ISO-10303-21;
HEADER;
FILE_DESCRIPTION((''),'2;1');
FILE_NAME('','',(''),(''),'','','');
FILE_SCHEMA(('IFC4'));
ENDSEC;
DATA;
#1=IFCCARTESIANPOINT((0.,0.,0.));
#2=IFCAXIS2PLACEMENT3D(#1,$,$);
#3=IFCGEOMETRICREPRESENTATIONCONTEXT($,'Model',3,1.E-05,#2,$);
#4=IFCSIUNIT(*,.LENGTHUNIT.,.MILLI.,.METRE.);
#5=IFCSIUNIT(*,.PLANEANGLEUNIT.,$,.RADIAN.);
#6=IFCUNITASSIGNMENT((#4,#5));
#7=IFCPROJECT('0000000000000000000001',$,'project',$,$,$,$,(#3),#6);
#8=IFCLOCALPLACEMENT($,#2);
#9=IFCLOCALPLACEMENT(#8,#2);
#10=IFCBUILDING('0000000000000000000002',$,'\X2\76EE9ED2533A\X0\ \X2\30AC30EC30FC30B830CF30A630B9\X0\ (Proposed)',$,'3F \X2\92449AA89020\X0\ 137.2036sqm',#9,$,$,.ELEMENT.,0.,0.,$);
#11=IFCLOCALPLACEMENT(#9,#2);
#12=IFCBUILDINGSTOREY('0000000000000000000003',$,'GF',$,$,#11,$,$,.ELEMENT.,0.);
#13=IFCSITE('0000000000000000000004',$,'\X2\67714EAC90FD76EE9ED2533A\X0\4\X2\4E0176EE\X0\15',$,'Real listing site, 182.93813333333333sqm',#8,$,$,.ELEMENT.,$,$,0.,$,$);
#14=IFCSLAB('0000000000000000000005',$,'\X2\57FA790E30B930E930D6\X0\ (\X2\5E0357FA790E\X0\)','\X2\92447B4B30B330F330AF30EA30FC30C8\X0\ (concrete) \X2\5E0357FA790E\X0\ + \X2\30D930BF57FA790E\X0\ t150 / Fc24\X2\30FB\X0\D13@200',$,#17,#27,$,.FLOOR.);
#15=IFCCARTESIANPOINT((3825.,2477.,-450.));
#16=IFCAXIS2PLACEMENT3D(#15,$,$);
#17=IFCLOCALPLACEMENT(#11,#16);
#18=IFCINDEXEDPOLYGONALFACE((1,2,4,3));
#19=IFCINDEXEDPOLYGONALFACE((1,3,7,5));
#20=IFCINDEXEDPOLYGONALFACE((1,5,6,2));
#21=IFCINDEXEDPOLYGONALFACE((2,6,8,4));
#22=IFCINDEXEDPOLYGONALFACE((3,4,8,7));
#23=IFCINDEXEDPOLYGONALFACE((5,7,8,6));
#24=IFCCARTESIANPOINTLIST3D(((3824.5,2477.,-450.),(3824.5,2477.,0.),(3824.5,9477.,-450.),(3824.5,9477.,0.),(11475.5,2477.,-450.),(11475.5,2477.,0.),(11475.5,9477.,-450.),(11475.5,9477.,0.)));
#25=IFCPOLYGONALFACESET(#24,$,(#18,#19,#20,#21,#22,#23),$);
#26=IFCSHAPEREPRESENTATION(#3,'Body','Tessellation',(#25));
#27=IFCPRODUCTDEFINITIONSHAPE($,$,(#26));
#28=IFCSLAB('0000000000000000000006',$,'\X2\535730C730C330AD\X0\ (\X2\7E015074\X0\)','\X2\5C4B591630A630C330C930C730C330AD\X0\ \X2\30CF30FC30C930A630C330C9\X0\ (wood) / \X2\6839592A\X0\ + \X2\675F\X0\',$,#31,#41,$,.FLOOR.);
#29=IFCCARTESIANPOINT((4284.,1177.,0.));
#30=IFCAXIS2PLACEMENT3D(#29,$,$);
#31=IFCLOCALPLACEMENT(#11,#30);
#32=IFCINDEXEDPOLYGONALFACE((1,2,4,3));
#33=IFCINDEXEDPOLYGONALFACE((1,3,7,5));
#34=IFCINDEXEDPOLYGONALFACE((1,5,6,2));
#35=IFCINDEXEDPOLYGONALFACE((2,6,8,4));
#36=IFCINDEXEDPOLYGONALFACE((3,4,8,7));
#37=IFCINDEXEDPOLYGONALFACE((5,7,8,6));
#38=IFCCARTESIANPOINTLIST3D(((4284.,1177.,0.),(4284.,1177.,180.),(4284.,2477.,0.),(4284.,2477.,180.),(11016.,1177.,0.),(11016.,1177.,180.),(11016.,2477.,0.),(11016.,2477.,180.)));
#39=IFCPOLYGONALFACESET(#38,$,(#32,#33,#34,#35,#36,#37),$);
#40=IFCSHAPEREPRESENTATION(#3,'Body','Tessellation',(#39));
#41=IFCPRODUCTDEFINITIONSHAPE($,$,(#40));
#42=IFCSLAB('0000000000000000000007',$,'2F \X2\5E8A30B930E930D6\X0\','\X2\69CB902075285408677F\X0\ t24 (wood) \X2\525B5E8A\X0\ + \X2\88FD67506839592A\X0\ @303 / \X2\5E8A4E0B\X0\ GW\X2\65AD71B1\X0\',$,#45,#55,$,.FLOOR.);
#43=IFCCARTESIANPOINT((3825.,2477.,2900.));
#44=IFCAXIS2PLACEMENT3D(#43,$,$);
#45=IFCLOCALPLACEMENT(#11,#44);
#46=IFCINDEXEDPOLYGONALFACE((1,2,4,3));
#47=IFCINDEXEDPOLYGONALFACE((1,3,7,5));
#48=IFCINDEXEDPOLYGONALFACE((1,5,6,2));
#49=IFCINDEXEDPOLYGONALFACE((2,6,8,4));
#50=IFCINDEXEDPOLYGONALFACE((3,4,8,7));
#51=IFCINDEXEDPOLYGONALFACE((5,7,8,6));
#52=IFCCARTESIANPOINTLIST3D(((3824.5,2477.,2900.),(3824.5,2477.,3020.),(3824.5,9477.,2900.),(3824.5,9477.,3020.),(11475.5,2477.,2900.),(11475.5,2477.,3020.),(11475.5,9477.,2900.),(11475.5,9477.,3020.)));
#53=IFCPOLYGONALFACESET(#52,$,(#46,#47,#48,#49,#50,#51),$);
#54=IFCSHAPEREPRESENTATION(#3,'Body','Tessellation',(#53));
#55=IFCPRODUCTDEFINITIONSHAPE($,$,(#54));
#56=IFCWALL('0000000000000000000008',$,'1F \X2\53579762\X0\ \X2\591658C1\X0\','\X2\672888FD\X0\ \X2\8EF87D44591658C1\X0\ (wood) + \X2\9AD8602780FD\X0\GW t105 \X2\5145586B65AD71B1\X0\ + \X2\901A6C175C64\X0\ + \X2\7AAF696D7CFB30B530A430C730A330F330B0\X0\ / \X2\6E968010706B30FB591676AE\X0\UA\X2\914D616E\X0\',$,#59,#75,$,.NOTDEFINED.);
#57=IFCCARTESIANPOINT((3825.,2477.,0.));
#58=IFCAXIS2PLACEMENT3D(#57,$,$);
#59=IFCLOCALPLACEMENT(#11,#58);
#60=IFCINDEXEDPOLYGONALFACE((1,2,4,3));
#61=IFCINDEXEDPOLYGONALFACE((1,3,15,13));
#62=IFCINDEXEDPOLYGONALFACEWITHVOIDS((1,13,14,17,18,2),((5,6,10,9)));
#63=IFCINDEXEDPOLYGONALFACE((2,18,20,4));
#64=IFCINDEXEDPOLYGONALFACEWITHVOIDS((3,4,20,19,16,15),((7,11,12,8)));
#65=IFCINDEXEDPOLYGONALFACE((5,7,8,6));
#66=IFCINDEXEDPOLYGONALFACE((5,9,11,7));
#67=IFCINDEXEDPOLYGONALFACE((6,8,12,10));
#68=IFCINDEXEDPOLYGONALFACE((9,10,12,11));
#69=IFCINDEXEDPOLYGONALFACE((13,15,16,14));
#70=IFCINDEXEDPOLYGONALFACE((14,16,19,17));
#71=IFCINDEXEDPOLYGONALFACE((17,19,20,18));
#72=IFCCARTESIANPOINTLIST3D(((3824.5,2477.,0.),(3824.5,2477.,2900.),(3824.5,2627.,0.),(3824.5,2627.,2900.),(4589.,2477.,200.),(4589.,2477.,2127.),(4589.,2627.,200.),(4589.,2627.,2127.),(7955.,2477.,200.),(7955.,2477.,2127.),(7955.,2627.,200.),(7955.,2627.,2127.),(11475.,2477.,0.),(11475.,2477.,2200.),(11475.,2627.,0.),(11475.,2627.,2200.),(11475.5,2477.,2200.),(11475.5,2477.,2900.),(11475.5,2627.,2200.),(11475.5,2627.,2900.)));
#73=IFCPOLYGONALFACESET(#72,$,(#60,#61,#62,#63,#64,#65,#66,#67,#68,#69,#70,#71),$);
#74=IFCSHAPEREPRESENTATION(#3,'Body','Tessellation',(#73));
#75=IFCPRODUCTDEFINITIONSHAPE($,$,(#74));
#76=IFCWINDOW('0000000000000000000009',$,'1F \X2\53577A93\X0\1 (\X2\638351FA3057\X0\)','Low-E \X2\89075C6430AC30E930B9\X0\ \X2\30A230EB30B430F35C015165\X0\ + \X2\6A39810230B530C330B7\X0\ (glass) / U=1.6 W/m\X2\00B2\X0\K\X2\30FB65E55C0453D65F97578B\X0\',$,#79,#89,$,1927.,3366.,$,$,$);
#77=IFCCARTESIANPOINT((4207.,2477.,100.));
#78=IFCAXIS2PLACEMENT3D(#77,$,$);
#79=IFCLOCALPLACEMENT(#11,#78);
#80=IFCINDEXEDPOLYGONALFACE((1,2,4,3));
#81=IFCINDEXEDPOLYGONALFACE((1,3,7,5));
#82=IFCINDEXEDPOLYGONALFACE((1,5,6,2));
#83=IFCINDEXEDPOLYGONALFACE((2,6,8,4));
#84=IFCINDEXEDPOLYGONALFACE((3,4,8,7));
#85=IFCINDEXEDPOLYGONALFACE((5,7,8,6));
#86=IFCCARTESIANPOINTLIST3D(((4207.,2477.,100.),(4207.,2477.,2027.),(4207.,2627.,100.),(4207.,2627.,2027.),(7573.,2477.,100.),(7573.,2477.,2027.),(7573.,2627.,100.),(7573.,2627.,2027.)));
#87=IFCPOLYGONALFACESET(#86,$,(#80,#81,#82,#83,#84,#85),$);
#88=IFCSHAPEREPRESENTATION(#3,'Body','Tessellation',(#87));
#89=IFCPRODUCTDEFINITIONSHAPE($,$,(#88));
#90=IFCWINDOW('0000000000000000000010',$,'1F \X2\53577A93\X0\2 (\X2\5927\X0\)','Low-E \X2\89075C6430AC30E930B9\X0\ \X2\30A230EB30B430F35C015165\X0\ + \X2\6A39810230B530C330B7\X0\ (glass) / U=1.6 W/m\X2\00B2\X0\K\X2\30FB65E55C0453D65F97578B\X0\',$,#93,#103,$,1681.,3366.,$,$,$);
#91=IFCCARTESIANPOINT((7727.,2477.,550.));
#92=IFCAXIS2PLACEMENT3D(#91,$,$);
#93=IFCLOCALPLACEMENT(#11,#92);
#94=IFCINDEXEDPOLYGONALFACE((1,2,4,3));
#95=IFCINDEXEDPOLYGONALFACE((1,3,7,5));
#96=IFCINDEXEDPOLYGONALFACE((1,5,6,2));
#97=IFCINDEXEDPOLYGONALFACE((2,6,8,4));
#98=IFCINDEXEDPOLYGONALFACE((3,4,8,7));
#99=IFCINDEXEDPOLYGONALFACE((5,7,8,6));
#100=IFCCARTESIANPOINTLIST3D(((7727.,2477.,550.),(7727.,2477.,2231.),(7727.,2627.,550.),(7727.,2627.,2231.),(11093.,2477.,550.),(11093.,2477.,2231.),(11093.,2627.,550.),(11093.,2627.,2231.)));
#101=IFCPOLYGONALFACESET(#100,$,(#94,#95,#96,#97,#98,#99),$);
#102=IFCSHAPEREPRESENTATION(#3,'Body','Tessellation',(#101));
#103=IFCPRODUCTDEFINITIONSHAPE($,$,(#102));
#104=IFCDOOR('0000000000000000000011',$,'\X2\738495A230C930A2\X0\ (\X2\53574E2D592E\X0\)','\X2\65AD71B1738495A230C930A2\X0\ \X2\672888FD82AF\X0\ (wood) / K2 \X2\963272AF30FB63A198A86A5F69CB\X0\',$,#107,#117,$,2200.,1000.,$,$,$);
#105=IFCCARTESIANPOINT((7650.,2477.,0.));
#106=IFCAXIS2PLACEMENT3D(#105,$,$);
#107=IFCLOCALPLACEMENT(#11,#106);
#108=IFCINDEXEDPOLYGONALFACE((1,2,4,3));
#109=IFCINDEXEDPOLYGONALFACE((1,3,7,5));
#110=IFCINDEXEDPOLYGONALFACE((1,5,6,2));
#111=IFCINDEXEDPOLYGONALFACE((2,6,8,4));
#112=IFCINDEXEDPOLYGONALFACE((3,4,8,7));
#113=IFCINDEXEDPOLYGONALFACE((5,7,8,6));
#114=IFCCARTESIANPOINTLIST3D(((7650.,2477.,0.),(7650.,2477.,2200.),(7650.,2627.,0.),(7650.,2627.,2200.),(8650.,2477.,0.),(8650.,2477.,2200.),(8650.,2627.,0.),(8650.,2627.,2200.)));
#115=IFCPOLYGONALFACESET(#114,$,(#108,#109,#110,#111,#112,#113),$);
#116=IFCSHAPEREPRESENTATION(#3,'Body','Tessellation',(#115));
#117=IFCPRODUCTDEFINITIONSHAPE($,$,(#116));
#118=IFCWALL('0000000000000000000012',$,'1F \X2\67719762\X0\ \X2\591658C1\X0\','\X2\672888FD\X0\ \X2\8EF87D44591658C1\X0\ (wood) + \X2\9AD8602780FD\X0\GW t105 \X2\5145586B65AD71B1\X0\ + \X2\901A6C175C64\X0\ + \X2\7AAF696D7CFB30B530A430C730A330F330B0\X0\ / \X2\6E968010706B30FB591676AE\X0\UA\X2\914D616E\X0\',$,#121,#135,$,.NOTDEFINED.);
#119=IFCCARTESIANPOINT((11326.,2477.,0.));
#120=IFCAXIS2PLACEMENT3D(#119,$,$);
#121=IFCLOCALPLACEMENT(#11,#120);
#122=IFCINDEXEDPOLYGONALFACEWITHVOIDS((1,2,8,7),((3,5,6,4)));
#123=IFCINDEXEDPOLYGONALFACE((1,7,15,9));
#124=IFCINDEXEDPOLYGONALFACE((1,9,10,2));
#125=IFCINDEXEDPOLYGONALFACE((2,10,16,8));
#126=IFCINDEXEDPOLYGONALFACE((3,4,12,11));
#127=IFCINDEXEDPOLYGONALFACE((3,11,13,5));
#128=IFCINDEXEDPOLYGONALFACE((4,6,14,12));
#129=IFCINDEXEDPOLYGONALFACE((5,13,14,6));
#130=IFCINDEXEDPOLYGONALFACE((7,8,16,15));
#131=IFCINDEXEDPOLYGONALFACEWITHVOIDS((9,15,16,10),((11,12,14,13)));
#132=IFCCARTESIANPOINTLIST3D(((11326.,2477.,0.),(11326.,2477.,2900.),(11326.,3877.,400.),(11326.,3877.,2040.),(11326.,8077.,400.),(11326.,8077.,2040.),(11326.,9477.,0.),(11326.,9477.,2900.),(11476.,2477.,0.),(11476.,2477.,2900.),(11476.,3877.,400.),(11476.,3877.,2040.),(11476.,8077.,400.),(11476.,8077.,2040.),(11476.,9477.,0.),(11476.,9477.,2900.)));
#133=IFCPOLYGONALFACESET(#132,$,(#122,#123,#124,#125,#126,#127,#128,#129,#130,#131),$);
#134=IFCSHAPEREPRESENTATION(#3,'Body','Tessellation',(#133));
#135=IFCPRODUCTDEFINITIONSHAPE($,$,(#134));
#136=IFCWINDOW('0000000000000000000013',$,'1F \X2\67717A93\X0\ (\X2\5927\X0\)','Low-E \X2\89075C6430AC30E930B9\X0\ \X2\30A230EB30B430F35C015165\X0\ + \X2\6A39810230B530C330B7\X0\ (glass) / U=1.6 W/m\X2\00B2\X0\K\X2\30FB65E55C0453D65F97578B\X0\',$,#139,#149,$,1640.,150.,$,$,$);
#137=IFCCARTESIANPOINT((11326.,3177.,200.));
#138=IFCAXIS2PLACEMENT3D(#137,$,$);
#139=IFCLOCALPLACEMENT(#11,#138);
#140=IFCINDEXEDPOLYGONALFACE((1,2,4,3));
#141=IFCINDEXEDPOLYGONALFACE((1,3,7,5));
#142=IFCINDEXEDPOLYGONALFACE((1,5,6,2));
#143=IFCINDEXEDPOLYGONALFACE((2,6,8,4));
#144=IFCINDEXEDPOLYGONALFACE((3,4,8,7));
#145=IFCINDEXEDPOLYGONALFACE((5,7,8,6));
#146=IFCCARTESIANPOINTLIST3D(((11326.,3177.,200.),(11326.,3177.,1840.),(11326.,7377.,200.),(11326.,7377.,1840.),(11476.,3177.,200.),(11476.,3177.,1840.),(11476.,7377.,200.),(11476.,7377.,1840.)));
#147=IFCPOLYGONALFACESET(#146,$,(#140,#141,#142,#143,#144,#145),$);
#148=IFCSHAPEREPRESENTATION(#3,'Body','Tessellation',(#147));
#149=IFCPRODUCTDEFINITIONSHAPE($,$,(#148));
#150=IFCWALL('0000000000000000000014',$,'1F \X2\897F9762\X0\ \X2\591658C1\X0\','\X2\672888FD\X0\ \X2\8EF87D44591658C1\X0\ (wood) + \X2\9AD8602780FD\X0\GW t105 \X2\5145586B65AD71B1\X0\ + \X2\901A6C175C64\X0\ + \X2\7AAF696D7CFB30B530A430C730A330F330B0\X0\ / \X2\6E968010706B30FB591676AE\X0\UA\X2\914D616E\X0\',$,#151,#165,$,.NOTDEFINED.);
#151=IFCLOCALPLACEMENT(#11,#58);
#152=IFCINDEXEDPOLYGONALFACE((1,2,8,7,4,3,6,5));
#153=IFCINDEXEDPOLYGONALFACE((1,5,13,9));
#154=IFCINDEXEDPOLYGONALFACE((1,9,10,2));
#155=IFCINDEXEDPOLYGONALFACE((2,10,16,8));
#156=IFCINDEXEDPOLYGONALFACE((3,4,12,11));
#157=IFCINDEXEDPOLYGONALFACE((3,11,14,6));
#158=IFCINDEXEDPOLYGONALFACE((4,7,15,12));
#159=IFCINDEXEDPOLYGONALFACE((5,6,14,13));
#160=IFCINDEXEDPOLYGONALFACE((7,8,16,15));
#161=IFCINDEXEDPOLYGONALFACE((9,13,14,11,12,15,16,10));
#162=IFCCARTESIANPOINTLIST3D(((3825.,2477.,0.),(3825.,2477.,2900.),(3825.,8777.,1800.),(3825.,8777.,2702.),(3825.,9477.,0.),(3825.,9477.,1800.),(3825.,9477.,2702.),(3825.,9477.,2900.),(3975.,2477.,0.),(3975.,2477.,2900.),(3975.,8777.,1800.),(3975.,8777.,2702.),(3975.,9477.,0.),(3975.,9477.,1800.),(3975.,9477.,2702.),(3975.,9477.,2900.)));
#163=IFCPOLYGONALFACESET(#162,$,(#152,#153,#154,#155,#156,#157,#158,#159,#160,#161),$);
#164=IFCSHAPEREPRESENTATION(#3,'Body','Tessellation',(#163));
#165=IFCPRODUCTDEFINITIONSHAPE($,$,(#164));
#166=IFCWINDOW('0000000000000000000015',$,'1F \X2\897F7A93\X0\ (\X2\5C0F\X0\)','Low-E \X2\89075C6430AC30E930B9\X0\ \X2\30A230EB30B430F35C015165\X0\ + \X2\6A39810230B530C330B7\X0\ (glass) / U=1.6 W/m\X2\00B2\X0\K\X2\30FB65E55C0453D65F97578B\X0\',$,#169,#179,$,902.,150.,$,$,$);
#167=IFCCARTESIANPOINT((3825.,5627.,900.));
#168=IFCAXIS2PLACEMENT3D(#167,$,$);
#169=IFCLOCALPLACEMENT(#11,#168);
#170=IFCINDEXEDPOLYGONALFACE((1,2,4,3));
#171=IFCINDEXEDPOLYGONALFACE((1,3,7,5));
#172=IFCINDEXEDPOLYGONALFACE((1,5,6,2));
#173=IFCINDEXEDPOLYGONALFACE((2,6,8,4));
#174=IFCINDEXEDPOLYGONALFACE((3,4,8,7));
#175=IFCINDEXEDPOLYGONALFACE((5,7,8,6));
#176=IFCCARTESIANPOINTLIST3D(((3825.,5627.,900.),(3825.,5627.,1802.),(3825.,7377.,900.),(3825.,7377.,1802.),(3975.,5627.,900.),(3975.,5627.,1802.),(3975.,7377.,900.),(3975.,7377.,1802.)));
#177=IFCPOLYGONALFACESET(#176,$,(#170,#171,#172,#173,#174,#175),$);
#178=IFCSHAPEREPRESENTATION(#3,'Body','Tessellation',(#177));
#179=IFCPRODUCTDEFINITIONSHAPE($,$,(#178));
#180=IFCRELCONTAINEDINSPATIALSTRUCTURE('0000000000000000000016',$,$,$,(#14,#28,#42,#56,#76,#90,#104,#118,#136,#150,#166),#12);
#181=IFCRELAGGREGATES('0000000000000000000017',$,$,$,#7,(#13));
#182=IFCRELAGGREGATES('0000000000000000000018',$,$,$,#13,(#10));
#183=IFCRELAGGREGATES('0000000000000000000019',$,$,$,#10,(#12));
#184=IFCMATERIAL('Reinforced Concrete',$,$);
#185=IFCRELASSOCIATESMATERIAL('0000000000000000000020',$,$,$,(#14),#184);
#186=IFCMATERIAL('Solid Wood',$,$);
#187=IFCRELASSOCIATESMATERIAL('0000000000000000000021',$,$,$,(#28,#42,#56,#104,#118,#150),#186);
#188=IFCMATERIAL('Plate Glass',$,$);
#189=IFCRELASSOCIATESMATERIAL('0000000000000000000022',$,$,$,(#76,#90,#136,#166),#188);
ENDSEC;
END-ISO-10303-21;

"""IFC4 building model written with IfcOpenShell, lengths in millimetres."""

from ifc_helpers import new_model, si_unit, frame, frame_2d, origin, place, context, project, spatial, rectangle, extrude, material, element, fill, save


model = new_model("IFC4")

# Units and contexts
model_context = context("Model", 3, precision=1e-05, world=origin())
ifc_project = project(units=[si_unit("LENGTHUNIT", "METRE", prefix="MILLI"), si_unit("PLANEANGLEUNIT", "RADIAN")], contexts=[model_context])

# Site, building, storey
site_placement = place(None, origin())
site = spatial("IfcSite", under=ifc_project, at=site_placement, Name="東京都目黒区4丁目15", ObjectType="Real listing site, 182.93813333333333sqm", CompositionType="ELEMENT", RefElevation=0.0)
building_placement = place(site_placement, origin())
building = spatial("IfcBuilding", under=site, at=building_placement, Name="目黒区 ガレージハウス (Proposed)", ObjectType="3F 鉄骨造 137.2036sqm", CompositionType="ELEMENT", ElevationOfRefHeight=0.0, ElevationOfTerrain=0.0)
storey_placement = place(building_placement, origin())
storey = spatial("IfcBuildingStorey", under=building, at=storey_placement, Name="GF", CompositionType="ELEMENT", Elevation=0.0)

# Slabs
ifc_material_1 = material(Name="Reinforced Concrete")
slab_1_placement = place(storey_placement, frame((3825.0, 2477.0, -450.0)))
element("IfcSlab", 1, at=slab_1_placement, inside=storey, material=ifc_material_1, Name="基礎スラブ (布基礎)", Description="鉄筋コンクリート (concrete) 布基礎 + ベタ基礎 t150 / Fc24・D13@200", PredefinedType="FLOOR", context=model_context, shape_type="SweptSolid", body=[
    extrude(rectangle(XDim=7651.0, YDim=7000.0, at=frame_2d((3825.0, 3500.0))), frame((3825.0, 2477.0, -450.0)), (0.0, 0.0, 1.0), 450.0),
])
ifc_material_2 = material(Name="Solid Wood")
slab_2_placement = place(storey_placement, frame((4284.0, 1177.0, 0.0)))
element("IfcSlab", 2, at=slab_2_placement, inside=storey, material=ifc_material_2, Name="南デッキ (縁側)", Description="屋外ウッドデッキ ハードウッド (wood) / 根太 + 束", PredefinedType="FLOOR", context=model_context, shape_type="SweptSolid", body=[
    extrude(rectangle(XDim=6732.0, YDim=1300.0, at=frame_2d((3366.0, 650.0))), frame((4284.0, 1177.0, 0.0)), (0.0, 0.0, 1.0), 180.0),
])
slab_3_placement = place(storey_placement, frame((3825.0, 2477.0, 2900.0)))
element("IfcSlab", 3, at=slab_3_placement, inside=storey, material=ifc_material_2, Name="2F 床スラブ", Description="構造用合板 t24 (wood) 剛床 + 製材根太 @303 / 床下 GW断熱", PredefinedType="FLOOR", context=model_context, shape_type="SweptSolid", body=[
    extrude(rectangle(XDim=7651.0, YDim=7000.0, at=frame_2d((3825.0, 3500.0))), frame((3825.0, 2477.0, 2900.0)), (0.0, 0.0, 1.0), 120.0),
])

# Wall, openings, windows, door
wall_1_placement = place(storey_placement, frame((3825.0, 2477.0, 0.0)))
wall_1 = element("IfcWall", 4, at=wall_1_placement, inside=storey, material=ifc_material_2, Name="1F 南面 外壁", Description="木製 軸組外壁 (wood) + 高性能GW t105 充填断熱 + 通気層 + 窯業系サイディング / 準耐火・外皮UA配慮", PredefinedType="NOTDEFINED", context=model_context, shape_type="SweptSolid", body=[
    extrude(rectangle(XDim=7651.0, YDim=150.0, at=frame_2d((3825.0, 75.0))), frame((3825.0, 2477.0, 0.0)), (0.0, 0.0, 1.0), 2900.0),
])
opening_1_placement = place(storey_placement, frame((4207.0, 2477.0, 100.0)))
opening_1 = element("IfcOpeningElement", 5, at=opening_1_placement, cuts=wall_1, PredefinedType="NOTDEFINED", context=model_context, shape_type="SweptSolid", body=[
    extrude(rectangle(XDim=3366.0, YDim=150.0, at=frame_2d((1683.0, 75.0))), frame((4207.0, 2477.0, 100.0)), (0.0, 0.0, 1.0), 1927.0),
])
opening_2_placement = place(storey_placement, frame((7727.0, 2477.0, 550.0)))
opening_2 = element("IfcOpeningElement", 6, at=opening_2_placement, cuts=wall_1, PredefinedType="NOTDEFINED", context=model_context, shape_type="SweptSolid", body=[
    extrude(rectangle(XDim=3366.0, YDim=150.0, at=frame_2d((1683.0, 75.0))), frame((7727.0, 2477.0, 550.0)), (0.0, 0.0, 1.0), 1681.0),
])
opening_3_placement = place(storey_placement, frame((7650.0, 2477.0, 0.0)))
opening_3 = element("IfcOpeningElement", 7, at=opening_3_placement, cuts=wall_1, PredefinedType="NOTDEFINED", context=model_context, shape_type="SweptSolid", body=[
    extrude(rectangle(XDim=1000.0, YDim=150.0, at=frame_2d((500.0, 75.0))), frame((7650.0, 2477.0, 0.0)), (0.0, 0.0, 1.0), 2200.0),
])
ifc_material_3 = material(Name="Plate Glass")
window_1_placement = place(storey_placement, frame((4207.0, 2477.0, 100.0)))
window_1 = element("IfcWindow", 8, at=window_1_placement, inside=storey, material=ifc_material_3, Name="1F 南窓1 (掃出し)", Description="Low-E 複層ガラス アルゴン封入 + 樹脂サッシ (glass) / U=1.6 W/m²K・日射取得型", OverallHeight=1927.0, OverallWidth=3366.0, context=model_context, shape_type="SweptSolid", body=[
    extrude(rectangle(XDim=3366.0, YDim=150.0, at=frame_2d((1683.0, 75.0))), frame((4207.0, 2477.0, 100.0)), (0.0, 0.0, 1.0), 1927.0),
])
fill(opening_1, window_1)
window_2_placement = place(storey_placement, frame((7727.0, 2477.0, 550.0)))
window_2 = element("IfcWindow", 9, at=window_2_placement, inside=storey, material=ifc_material_3, Name="1F 南窓2 (大)", Description="Low-E 複層ガラス アルゴン封入 + 樹脂サッシ (glass) / U=1.6 W/m²K・日射取得型", OverallHeight=1681.0, OverallWidth=3366.0, context=model_context, shape_type="SweptSolid", body=[
    extrude(rectangle(XDim=3366.0, YDim=150.0, at=frame_2d((1683.0, 75.0))), frame((7727.0, 2477.0, 550.0)), (0.0, 0.0, 1.0), 1681.0),
])
fill(opening_2, window_2)
door_placement = place(storey_placement, frame((7650.0, 2477.0, 0.0)))
door = element("IfcDoor", 10, at=door_placement, inside=storey, material=ifc_material_2, Name="玄関ドア (南中央)", Description="断熱玄関ドア 木製芯 (wood) / K2 防犯・採風機構", OverallHeight=2200.0, OverallWidth=1000.0, context=model_context, shape_type="SweptSolid", body=[
    extrude(rectangle(XDim=1000.0, YDim=150.0, at=frame_2d((500.0, 75.0))), frame((7650.0, 2477.0, 0.0)), (0.0, 0.0, 1.0), 2200.0),
])
fill(opening_3, door)

# Walls, openings, windows
wall_2_placement = place(storey_placement, frame((11326.0, 2477.0, 0.0)))
wall_2 = element("IfcWall", 11, at=wall_2_placement, inside=storey, material=ifc_material_2, Name="1F 東面 外壁", Description="木製 軸組外壁 (wood) + 高性能GW t105 充填断熱 + 通気層 + 窯業系サイディング / 準耐火・外皮UA配慮", PredefinedType="NOTDEFINED", context=model_context, shape_type="SweptSolid", body=[
    extrude(rectangle(XDim=150.0, YDim=7000.0, at=frame_2d((75.0, 3500.0))), frame((11326.0, 2477.0, 0.0)), (0.0, 0.0, 1.0), 2900.0),
])
opening_4_placement = place(storey_placement, frame((11326.0, 3177.0, 200.0)))
opening_4 = element("IfcOpeningElement", 12, at=opening_4_placement, cuts=wall_2, PredefinedType="NOTDEFINED", context=model_context, shape_type="SweptSolid", body=[
    extrude(rectangle(XDim=150.0, YDim=4200.0, at=frame_2d((75.0, 2100.0))), frame((11326.0, 3177.0, 200.0)), (0.0, 0.0, 1.0), 1640.0),
])
window_3_placement = place(storey_placement, frame((11326.0, 3177.0, 200.0)))
window_3 = element("IfcWindow", 13, at=window_3_placement, inside=storey, material=ifc_material_3, Name="1F 東窓 (大)", Description="Low-E 複層ガラス アルゴン封入 + 樹脂サッシ (glass) / U=1.6 W/m²K・日射取得型", OverallHeight=1640.0, OverallWidth=150.0, context=model_context, shape_type="SweptSolid", body=[
    extrude(rectangle(XDim=150.0, YDim=4200.0, at=frame_2d((75.0, 2100.0))), frame((11326.0, 3177.0, 200.0)), (0.0, 0.0, 1.0), 1640.0),
])
fill(opening_4, window_3)
wall_3_placement = place(storey_placement, frame((3825.0, 2477.0, 0.0)))
wall_3 = element("IfcWall", 14, at=wall_3_placement, inside=storey, material=ifc_material_2, Name="1F 西面 外壁", Description="木製 軸組外壁 (wood) + 高性能GW t105 充填断熱 + 通気層 + 窯業系サイディング / 準耐火・外皮UA配慮", PredefinedType="NOTDEFINED", context=model_context, shape_type="SweptSolid", body=[
    extrude(rectangle(XDim=150.0, YDim=7000.0, at=frame_2d((75.0, 3500.0))), frame((3825.0, 2477.0, 0.0)), (0.0, 0.0, 1.0), 2900.0),
])
opening_5_placement = place(storey_placement, frame((3825.0, 5627.0, 900.0)))
opening_5 = element("IfcOpeningElement", 15, at=opening_5_placement, cuts=wall_3, PredefinedType="NOTDEFINED", context=model_context, shape_type="SweptSolid", body=[
    extrude(rectangle(XDim=150.0, YDim=1750.0, at=frame_2d((75.0, 875.0))), frame((3825.0, 5627.0, 900.0)), (0.0, 0.0, 1.0), 902.0),
])
window_4_placement = place(storey_placement, frame((3825.0, 5627.0, 900.0)))
window_4 = element("IfcWindow", 16, at=window_4_placement, inside=storey, material=ifc_material_3, Name="1F 西窓 (小)", Description="Low-E 複層ガラス アルゴン封入 + 樹脂サッシ (glass) / U=1.6 W/m²K・日射取得型", OverallHeight=902.0, OverallWidth=150.0, context=model_context, shape_type="SweptSolid", body=[
    extrude(rectangle(XDim=150.0, YDim=1750.0, at=frame_2d((75.0, 875.0))), frame((3825.0, 5627.0, 900.0)), (0.0, 0.0, 1.0), 902.0),
])
fill(opening_5, window_4)

save(model, "model.ifc")
